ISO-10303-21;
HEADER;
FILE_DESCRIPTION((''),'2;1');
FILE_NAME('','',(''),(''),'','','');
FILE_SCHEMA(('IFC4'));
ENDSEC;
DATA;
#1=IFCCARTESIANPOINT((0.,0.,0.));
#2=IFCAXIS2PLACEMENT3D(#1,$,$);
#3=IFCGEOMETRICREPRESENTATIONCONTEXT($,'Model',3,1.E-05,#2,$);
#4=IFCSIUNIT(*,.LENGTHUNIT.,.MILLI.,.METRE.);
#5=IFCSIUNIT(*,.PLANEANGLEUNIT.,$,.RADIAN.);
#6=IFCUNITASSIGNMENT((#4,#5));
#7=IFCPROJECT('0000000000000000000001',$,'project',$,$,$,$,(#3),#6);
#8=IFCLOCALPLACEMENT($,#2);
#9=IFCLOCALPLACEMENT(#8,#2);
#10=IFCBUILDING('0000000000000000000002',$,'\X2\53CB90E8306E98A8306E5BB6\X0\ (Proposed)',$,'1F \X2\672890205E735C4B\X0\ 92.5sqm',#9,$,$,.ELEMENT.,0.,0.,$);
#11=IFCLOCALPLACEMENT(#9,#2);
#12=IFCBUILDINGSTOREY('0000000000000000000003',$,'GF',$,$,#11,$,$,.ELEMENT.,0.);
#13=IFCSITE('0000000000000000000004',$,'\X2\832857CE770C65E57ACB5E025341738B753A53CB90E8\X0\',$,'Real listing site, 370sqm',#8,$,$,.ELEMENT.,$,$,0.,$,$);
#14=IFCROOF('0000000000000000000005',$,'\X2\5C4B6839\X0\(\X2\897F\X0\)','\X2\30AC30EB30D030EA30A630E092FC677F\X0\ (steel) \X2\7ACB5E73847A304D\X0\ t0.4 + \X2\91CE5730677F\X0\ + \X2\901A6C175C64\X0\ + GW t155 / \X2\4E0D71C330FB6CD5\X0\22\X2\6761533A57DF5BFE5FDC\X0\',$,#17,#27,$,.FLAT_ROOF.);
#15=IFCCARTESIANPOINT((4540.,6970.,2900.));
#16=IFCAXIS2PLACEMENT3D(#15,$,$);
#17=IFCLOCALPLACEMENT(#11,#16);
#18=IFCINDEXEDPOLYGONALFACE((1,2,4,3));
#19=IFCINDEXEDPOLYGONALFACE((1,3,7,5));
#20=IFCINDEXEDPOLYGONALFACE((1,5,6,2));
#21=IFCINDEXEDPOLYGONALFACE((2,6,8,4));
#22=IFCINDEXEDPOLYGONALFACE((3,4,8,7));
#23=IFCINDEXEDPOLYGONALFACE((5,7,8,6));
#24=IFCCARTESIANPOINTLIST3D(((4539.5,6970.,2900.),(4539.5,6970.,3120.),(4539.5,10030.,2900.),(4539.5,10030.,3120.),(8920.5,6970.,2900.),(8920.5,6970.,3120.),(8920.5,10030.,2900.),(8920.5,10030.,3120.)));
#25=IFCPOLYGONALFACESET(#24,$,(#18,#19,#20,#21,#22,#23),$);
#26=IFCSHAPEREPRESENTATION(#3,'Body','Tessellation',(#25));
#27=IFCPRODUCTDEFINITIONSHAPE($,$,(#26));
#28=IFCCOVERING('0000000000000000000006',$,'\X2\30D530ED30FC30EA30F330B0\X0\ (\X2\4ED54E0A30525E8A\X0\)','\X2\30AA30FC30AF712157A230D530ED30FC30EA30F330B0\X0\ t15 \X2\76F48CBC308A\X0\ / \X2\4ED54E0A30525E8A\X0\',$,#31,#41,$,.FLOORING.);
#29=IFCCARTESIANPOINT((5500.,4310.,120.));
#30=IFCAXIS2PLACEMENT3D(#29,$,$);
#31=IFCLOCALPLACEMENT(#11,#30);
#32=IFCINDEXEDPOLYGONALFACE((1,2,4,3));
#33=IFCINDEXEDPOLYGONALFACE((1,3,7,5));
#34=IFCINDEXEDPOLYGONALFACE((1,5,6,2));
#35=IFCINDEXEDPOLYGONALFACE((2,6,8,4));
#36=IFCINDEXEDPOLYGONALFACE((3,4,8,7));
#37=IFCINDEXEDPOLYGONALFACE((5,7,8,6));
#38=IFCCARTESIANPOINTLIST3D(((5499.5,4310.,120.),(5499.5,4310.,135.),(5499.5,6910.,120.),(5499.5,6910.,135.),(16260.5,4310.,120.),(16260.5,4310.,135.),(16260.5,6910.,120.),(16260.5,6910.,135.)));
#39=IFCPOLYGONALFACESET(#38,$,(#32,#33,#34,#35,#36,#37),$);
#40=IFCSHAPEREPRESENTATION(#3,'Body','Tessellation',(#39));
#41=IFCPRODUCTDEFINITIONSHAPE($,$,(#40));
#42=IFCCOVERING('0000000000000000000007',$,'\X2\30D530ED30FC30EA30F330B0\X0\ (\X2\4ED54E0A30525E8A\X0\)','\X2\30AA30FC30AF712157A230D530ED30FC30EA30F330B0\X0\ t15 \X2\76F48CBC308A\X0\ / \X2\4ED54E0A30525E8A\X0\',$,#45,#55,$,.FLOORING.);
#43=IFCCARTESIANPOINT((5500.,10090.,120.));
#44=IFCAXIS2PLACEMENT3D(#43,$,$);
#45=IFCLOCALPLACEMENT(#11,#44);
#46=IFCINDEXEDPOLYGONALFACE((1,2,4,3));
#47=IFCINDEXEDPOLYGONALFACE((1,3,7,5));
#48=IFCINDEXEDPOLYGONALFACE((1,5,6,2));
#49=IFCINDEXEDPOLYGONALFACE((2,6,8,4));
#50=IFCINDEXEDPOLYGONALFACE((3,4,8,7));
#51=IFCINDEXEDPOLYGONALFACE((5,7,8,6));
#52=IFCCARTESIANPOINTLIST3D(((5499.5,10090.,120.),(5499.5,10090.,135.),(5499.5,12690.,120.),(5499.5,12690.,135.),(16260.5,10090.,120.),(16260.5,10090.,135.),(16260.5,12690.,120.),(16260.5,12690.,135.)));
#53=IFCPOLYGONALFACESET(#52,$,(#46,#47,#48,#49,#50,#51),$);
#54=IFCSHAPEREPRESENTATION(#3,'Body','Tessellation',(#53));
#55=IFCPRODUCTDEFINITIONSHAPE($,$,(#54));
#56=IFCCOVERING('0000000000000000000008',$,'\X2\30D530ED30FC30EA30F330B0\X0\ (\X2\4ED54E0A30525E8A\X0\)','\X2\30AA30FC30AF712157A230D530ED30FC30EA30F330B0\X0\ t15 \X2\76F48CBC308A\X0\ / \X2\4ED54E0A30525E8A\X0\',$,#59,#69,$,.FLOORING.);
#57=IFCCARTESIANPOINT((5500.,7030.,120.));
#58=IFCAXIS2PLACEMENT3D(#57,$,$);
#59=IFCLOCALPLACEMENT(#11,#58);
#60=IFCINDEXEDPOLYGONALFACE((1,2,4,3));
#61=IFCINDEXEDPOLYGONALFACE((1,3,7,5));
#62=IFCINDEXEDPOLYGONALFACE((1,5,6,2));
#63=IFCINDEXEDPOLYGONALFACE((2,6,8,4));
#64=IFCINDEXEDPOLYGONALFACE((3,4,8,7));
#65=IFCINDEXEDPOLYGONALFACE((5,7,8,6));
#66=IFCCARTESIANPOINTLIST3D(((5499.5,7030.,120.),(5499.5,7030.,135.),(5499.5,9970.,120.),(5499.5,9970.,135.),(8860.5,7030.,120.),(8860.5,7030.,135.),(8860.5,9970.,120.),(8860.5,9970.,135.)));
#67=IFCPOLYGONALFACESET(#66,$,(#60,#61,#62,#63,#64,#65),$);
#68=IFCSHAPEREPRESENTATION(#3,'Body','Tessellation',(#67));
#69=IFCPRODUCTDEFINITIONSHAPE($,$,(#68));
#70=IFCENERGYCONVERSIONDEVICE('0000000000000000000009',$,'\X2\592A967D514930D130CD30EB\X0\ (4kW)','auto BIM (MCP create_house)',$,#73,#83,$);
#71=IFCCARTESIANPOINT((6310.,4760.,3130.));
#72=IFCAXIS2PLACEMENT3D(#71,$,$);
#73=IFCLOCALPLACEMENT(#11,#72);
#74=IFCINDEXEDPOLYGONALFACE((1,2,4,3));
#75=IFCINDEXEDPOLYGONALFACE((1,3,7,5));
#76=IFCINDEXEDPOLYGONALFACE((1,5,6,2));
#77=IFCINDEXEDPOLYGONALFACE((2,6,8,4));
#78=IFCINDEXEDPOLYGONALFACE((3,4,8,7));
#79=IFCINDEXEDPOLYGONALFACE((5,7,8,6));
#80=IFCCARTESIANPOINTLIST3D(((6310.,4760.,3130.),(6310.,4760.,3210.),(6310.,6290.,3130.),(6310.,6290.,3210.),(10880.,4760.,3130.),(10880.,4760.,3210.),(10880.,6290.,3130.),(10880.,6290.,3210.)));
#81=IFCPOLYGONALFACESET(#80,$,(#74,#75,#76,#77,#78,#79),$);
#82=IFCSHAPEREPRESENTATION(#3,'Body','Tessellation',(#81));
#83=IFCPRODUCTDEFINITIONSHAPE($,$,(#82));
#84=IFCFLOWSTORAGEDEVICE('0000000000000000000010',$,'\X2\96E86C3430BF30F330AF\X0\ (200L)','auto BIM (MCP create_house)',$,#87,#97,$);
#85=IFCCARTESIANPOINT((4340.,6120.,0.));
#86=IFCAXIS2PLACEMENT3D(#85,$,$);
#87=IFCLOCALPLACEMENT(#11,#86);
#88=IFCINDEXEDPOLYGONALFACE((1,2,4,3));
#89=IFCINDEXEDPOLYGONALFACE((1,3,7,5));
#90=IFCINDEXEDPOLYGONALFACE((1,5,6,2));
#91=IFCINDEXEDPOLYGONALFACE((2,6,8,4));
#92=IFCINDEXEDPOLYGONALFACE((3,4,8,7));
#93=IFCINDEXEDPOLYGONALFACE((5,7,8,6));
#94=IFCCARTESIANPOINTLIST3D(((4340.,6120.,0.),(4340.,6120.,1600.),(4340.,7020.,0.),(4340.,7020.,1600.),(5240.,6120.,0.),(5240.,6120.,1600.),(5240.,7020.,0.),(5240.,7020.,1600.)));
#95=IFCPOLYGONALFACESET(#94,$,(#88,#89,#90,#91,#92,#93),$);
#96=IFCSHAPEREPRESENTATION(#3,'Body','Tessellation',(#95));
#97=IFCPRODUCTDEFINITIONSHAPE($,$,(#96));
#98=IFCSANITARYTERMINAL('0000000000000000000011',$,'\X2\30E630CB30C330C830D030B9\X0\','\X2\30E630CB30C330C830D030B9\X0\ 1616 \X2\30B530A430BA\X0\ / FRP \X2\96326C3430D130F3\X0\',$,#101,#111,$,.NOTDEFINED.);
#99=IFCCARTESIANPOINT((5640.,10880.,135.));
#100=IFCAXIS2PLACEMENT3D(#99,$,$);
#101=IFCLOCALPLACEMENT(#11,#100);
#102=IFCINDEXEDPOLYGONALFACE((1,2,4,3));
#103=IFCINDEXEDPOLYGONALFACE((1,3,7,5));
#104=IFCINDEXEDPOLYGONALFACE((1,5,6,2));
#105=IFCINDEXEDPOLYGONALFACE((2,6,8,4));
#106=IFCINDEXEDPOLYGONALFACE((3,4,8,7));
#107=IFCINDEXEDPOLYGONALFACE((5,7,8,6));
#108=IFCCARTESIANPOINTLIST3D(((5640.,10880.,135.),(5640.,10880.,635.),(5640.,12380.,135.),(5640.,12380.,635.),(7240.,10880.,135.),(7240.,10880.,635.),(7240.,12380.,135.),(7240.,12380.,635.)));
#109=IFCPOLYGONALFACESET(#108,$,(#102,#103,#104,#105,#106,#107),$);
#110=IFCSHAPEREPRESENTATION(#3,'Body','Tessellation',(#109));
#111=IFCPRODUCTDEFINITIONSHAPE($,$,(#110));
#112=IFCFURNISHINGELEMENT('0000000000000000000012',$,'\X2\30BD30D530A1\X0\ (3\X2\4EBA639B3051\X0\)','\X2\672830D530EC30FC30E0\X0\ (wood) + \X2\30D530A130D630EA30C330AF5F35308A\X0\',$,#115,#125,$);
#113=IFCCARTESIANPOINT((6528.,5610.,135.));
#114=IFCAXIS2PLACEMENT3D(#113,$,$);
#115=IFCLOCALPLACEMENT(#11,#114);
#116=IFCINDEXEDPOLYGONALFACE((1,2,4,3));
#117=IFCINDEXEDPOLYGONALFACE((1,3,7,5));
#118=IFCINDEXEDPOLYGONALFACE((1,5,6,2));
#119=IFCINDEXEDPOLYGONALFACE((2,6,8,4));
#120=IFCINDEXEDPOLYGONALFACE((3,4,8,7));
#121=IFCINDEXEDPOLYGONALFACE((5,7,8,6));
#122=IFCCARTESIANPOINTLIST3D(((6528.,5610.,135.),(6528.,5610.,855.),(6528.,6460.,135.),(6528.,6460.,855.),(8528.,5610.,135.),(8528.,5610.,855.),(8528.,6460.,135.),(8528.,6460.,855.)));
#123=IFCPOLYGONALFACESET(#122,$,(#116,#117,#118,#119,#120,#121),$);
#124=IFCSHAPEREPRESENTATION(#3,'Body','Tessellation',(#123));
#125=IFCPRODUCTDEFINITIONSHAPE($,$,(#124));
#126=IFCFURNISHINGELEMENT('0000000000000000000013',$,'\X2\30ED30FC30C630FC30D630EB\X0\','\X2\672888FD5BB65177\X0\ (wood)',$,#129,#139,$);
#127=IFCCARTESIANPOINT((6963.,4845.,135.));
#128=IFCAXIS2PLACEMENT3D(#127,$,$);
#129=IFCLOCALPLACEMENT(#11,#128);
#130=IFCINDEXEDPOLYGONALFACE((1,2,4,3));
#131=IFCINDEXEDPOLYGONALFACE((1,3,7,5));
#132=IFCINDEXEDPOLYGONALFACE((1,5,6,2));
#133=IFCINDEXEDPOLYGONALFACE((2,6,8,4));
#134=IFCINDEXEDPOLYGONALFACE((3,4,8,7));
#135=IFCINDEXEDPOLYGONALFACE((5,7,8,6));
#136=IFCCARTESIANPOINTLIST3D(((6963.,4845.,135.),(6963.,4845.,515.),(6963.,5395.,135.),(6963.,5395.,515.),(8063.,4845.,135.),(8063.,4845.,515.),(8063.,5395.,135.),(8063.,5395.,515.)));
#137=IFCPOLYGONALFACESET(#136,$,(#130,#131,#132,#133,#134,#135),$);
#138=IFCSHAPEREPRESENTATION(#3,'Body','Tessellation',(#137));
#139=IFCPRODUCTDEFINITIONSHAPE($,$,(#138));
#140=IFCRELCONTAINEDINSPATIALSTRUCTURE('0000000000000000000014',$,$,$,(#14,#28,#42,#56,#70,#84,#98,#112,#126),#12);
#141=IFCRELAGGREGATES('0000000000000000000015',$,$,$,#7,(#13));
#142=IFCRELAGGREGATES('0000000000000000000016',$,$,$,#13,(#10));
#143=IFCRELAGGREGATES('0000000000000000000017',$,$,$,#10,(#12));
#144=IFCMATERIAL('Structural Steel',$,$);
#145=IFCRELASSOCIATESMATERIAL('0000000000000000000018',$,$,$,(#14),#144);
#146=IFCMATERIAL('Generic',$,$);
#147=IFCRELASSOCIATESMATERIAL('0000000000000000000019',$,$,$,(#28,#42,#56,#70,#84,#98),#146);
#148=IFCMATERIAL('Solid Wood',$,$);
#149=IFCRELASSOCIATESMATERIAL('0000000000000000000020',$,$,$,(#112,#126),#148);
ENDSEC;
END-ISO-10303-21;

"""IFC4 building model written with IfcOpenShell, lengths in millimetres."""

from ifc_helpers import new_model, si_unit, frame, frame_2d, origin, place, context, project, spatial, rectangle, extrude, material, element, save


model = new_model("IFC4")

# Units and contexts
model_context = context("Model", 3, precision=1e-05, world=origin())
ifc_project = project(units=[si_unit("LENGTHUNIT", "METRE", prefix="MILLI"), si_unit("PLANEANGLEUNIT", "RADIAN")], contexts=[model_context])

# Site, building, storey
site_placement = place(None, origin())
site = spatial("IfcSite", under=ifc_project, at=site_placement, Name="茨城県日立市十王町友部", ObjectType="Real listing site, 370sqm", CompositionType="ELEMENT", RefElevation=0.0)
building_placement = place(site_placement, origin())
building = spatial("IfcBuilding", under=site, at=building_placement, Name="友部の風の家 (Proposed)", ObjectType="1F 木造平屋 92.5sqm", CompositionType="ELEMENT", ElevationOfRefHeight=0.0, ElevationOfTerrain=0.0)
storey_placement = place(building_placement, origin())
storey = spatial("IfcBuildingStorey", under=building, at=storey_placement, Name="GF", CompositionType="ELEMENT", Elevation=0.0)

# Shared definitions
ifc_material_1 = material(Name="Solid Wood")

# Roof
ifc_material_2 = material(Name="Structural Steel")
roof_1_placement = place(storey_placement, frame((4540.0, 6970.0, 2900.0)))
element("IfcRoof", 1, at=roof_1_placement, inside=storey, material=ifc_material_2, Name="屋根(西)", Description="ガルバリウム鋼板 (steel) 立平葺き t0.4 + 野地板 + 通気層 + GW t155 / 不燃・法22条区域対応", PredefinedType="FLAT_ROOF", context=model_context, shape_type="SweptSolid", body=[
    extrude(rectangle(XDim=4381.0, YDim=3060.0, at=frame_2d((2190.0, 1530.0))), frame((4540.0, 6970.0, 2900.0)), (0.0, 0.0, 1.0), 220.0),
])

# Coverings
ifc_material_3 = material(Name="Generic")
covering_1_placement = place(storey_placement, frame((5500.0, 4310.0, 120.0)))
element("IfcCovering", 2, at=covering_1_placement, inside=storey, material=ifc_material_3, Name="フローリング (仕上げ床)", Description="オーク無垢フローリング t15 直貼り / 仕上げ床", PredefinedType="FLOORING", context=model_context, shape_type="SweptSolid", body=[
    extrude(rectangle(XDim=10761.0, YDim=2600.0, at=frame_2d((5380.0, 1300.0))), frame((5500.0, 4310.0, 120.0)), (0.0, 0.0, 1.0), 15.0),
])
covering_2_placement = place(storey_placement, frame((5500.0, 10090.0, 120.0)))
element("IfcCovering", 3, at=covering_2_placement, inside=storey, material=ifc_material_3, Name="フローリング (仕上げ床)", Description="オーク無垢フローリング t15 直貼り / 仕上げ床", PredefinedType="FLOORING", context=model_context, shape_type="SweptSolid", body=[
    extrude(rectangle(XDim=10761.0, YDim=2600.0, at=frame_2d((5380.0, 1300.0))), frame((5500.0, 10090.0, 120.0)), (0.0, 0.0, 1.0), 15.0),
])
covering_3_placement = place(storey_placement, frame((5500.0, 7030.0, 120.0)))
element("IfcCovering", 4, at=covering_3_placement, inside=storey, material=ifc_material_3, Name="フローリング (仕上げ床)", Description="オーク無垢フローリング t15 直貼り / 仕上げ床", PredefinedType="FLOORING", context=model_context, shape_type="SweptSolid", body=[
    extrude(rectangle(XDim=3361.0, YDim=2940.0, at=frame_2d((1680.0, 1470.0))), frame((5500.0, 7030.0, 120.0)), (0.0, 0.0, 1.0), 15.0),
])

# Energy conversion device
energy_conversion_device_placement = place(storey_placement, frame((6310.0, 4760.0, 3130.0)))
element("IfcEnergyConversionDevice", 5, at=energy_conversion_device_placement, inside=storey, material=ifc_material_3, Name="太陽光パネル (4kW)", Description="auto BIM (MCP create_house)", context=model_context, shape_type="SweptSolid", body=[
    extrude(rectangle(XDim=4570.0, YDim=1530.0, at=frame_2d((2285.0, 765.0))), frame((6310.0, 4760.0, 3130.0)), (0.0, 0.0, 1.0), 80.0),
])

# Flow storage device
flow_storage_device_placement = place(storey_placement, frame((4340.0, 6120.0, 0.0)))
element("IfcFlowStorageDevice", 6, at=flow_storage_device_placement, inside=storey, material=ifc_material_3, Name="雨水タンク (200L)", Description="auto BIM (MCP create_house)", context=model_context, shape_type="SweptSolid", body=[
    extrude(rectangle(XDim=900.0, YDim=900.0, at=frame_2d((450.0, 450.0))), frame((4340.0, 6120.0, 0.0)), (0.0, 0.0, 1.0), 1600.0),
])

# Sanitary terminal
sanitary_terminal_placement = place(storey_placement, frame((5640.0, 10880.0, 135.0)))
element("IfcSanitaryTerminal", 7, at=sanitary_terminal_placement, inside=storey, material=ifc_material_3, Name="ユニットバス", Description="ユニットバス 1616 サイズ / FRP 防水パン", PredefinedType="NOTDEFINED", context=model_context, shape_type="SweptSolid", body=[
    extrude(rectangle(XDim=1600.0, YDim=1500.0, at=frame_2d((800.0, 750.0))), frame((5640.0, 10880.0, 135.0)), (0.0, 0.0, 1.0), 500.0),
])

# Furnishing elements
furnishing_1_placement = place(storey_placement, frame((6528.0, 5610.0, 135.0)))
element("IfcFurnishingElement", 8, at=furnishing_1_placement, inside=storey, material=ifc_material_1, Name="ソファ (3人掛け)", Description="木フレーム (wood) + ファブリック張り", context=model_context, shape_type="SweptSolid", body=[
    extrude(rectangle(XDim=2000.0, YDim=850.0, at=frame_2d((1000.0, 425.0))), frame((6528.0, 5610.0, 135.0)), (0.0, 0.0, 1.0), 720.0),
])
furnishing_2_placement = place(storey_placement, frame((6963.0, 4845.0, 135.0)))
element("IfcFurnishingElement", 9, at=furnishing_2_placement, inside=storey, material=ifc_material_1, Name="ローテーブル", Description="木製家具 (wood)", context=model_context, shape_type="SweptSolid", body=[
    extrude(rectangle(XDim=1100.0, YDim=550.0, at=frame_2d((550.0, 275.0))), frame((6963.0, 4845.0, 135.0)), (0.0, 0.0, 1.0), 380.0),
])

save(model, "model.ifc")
